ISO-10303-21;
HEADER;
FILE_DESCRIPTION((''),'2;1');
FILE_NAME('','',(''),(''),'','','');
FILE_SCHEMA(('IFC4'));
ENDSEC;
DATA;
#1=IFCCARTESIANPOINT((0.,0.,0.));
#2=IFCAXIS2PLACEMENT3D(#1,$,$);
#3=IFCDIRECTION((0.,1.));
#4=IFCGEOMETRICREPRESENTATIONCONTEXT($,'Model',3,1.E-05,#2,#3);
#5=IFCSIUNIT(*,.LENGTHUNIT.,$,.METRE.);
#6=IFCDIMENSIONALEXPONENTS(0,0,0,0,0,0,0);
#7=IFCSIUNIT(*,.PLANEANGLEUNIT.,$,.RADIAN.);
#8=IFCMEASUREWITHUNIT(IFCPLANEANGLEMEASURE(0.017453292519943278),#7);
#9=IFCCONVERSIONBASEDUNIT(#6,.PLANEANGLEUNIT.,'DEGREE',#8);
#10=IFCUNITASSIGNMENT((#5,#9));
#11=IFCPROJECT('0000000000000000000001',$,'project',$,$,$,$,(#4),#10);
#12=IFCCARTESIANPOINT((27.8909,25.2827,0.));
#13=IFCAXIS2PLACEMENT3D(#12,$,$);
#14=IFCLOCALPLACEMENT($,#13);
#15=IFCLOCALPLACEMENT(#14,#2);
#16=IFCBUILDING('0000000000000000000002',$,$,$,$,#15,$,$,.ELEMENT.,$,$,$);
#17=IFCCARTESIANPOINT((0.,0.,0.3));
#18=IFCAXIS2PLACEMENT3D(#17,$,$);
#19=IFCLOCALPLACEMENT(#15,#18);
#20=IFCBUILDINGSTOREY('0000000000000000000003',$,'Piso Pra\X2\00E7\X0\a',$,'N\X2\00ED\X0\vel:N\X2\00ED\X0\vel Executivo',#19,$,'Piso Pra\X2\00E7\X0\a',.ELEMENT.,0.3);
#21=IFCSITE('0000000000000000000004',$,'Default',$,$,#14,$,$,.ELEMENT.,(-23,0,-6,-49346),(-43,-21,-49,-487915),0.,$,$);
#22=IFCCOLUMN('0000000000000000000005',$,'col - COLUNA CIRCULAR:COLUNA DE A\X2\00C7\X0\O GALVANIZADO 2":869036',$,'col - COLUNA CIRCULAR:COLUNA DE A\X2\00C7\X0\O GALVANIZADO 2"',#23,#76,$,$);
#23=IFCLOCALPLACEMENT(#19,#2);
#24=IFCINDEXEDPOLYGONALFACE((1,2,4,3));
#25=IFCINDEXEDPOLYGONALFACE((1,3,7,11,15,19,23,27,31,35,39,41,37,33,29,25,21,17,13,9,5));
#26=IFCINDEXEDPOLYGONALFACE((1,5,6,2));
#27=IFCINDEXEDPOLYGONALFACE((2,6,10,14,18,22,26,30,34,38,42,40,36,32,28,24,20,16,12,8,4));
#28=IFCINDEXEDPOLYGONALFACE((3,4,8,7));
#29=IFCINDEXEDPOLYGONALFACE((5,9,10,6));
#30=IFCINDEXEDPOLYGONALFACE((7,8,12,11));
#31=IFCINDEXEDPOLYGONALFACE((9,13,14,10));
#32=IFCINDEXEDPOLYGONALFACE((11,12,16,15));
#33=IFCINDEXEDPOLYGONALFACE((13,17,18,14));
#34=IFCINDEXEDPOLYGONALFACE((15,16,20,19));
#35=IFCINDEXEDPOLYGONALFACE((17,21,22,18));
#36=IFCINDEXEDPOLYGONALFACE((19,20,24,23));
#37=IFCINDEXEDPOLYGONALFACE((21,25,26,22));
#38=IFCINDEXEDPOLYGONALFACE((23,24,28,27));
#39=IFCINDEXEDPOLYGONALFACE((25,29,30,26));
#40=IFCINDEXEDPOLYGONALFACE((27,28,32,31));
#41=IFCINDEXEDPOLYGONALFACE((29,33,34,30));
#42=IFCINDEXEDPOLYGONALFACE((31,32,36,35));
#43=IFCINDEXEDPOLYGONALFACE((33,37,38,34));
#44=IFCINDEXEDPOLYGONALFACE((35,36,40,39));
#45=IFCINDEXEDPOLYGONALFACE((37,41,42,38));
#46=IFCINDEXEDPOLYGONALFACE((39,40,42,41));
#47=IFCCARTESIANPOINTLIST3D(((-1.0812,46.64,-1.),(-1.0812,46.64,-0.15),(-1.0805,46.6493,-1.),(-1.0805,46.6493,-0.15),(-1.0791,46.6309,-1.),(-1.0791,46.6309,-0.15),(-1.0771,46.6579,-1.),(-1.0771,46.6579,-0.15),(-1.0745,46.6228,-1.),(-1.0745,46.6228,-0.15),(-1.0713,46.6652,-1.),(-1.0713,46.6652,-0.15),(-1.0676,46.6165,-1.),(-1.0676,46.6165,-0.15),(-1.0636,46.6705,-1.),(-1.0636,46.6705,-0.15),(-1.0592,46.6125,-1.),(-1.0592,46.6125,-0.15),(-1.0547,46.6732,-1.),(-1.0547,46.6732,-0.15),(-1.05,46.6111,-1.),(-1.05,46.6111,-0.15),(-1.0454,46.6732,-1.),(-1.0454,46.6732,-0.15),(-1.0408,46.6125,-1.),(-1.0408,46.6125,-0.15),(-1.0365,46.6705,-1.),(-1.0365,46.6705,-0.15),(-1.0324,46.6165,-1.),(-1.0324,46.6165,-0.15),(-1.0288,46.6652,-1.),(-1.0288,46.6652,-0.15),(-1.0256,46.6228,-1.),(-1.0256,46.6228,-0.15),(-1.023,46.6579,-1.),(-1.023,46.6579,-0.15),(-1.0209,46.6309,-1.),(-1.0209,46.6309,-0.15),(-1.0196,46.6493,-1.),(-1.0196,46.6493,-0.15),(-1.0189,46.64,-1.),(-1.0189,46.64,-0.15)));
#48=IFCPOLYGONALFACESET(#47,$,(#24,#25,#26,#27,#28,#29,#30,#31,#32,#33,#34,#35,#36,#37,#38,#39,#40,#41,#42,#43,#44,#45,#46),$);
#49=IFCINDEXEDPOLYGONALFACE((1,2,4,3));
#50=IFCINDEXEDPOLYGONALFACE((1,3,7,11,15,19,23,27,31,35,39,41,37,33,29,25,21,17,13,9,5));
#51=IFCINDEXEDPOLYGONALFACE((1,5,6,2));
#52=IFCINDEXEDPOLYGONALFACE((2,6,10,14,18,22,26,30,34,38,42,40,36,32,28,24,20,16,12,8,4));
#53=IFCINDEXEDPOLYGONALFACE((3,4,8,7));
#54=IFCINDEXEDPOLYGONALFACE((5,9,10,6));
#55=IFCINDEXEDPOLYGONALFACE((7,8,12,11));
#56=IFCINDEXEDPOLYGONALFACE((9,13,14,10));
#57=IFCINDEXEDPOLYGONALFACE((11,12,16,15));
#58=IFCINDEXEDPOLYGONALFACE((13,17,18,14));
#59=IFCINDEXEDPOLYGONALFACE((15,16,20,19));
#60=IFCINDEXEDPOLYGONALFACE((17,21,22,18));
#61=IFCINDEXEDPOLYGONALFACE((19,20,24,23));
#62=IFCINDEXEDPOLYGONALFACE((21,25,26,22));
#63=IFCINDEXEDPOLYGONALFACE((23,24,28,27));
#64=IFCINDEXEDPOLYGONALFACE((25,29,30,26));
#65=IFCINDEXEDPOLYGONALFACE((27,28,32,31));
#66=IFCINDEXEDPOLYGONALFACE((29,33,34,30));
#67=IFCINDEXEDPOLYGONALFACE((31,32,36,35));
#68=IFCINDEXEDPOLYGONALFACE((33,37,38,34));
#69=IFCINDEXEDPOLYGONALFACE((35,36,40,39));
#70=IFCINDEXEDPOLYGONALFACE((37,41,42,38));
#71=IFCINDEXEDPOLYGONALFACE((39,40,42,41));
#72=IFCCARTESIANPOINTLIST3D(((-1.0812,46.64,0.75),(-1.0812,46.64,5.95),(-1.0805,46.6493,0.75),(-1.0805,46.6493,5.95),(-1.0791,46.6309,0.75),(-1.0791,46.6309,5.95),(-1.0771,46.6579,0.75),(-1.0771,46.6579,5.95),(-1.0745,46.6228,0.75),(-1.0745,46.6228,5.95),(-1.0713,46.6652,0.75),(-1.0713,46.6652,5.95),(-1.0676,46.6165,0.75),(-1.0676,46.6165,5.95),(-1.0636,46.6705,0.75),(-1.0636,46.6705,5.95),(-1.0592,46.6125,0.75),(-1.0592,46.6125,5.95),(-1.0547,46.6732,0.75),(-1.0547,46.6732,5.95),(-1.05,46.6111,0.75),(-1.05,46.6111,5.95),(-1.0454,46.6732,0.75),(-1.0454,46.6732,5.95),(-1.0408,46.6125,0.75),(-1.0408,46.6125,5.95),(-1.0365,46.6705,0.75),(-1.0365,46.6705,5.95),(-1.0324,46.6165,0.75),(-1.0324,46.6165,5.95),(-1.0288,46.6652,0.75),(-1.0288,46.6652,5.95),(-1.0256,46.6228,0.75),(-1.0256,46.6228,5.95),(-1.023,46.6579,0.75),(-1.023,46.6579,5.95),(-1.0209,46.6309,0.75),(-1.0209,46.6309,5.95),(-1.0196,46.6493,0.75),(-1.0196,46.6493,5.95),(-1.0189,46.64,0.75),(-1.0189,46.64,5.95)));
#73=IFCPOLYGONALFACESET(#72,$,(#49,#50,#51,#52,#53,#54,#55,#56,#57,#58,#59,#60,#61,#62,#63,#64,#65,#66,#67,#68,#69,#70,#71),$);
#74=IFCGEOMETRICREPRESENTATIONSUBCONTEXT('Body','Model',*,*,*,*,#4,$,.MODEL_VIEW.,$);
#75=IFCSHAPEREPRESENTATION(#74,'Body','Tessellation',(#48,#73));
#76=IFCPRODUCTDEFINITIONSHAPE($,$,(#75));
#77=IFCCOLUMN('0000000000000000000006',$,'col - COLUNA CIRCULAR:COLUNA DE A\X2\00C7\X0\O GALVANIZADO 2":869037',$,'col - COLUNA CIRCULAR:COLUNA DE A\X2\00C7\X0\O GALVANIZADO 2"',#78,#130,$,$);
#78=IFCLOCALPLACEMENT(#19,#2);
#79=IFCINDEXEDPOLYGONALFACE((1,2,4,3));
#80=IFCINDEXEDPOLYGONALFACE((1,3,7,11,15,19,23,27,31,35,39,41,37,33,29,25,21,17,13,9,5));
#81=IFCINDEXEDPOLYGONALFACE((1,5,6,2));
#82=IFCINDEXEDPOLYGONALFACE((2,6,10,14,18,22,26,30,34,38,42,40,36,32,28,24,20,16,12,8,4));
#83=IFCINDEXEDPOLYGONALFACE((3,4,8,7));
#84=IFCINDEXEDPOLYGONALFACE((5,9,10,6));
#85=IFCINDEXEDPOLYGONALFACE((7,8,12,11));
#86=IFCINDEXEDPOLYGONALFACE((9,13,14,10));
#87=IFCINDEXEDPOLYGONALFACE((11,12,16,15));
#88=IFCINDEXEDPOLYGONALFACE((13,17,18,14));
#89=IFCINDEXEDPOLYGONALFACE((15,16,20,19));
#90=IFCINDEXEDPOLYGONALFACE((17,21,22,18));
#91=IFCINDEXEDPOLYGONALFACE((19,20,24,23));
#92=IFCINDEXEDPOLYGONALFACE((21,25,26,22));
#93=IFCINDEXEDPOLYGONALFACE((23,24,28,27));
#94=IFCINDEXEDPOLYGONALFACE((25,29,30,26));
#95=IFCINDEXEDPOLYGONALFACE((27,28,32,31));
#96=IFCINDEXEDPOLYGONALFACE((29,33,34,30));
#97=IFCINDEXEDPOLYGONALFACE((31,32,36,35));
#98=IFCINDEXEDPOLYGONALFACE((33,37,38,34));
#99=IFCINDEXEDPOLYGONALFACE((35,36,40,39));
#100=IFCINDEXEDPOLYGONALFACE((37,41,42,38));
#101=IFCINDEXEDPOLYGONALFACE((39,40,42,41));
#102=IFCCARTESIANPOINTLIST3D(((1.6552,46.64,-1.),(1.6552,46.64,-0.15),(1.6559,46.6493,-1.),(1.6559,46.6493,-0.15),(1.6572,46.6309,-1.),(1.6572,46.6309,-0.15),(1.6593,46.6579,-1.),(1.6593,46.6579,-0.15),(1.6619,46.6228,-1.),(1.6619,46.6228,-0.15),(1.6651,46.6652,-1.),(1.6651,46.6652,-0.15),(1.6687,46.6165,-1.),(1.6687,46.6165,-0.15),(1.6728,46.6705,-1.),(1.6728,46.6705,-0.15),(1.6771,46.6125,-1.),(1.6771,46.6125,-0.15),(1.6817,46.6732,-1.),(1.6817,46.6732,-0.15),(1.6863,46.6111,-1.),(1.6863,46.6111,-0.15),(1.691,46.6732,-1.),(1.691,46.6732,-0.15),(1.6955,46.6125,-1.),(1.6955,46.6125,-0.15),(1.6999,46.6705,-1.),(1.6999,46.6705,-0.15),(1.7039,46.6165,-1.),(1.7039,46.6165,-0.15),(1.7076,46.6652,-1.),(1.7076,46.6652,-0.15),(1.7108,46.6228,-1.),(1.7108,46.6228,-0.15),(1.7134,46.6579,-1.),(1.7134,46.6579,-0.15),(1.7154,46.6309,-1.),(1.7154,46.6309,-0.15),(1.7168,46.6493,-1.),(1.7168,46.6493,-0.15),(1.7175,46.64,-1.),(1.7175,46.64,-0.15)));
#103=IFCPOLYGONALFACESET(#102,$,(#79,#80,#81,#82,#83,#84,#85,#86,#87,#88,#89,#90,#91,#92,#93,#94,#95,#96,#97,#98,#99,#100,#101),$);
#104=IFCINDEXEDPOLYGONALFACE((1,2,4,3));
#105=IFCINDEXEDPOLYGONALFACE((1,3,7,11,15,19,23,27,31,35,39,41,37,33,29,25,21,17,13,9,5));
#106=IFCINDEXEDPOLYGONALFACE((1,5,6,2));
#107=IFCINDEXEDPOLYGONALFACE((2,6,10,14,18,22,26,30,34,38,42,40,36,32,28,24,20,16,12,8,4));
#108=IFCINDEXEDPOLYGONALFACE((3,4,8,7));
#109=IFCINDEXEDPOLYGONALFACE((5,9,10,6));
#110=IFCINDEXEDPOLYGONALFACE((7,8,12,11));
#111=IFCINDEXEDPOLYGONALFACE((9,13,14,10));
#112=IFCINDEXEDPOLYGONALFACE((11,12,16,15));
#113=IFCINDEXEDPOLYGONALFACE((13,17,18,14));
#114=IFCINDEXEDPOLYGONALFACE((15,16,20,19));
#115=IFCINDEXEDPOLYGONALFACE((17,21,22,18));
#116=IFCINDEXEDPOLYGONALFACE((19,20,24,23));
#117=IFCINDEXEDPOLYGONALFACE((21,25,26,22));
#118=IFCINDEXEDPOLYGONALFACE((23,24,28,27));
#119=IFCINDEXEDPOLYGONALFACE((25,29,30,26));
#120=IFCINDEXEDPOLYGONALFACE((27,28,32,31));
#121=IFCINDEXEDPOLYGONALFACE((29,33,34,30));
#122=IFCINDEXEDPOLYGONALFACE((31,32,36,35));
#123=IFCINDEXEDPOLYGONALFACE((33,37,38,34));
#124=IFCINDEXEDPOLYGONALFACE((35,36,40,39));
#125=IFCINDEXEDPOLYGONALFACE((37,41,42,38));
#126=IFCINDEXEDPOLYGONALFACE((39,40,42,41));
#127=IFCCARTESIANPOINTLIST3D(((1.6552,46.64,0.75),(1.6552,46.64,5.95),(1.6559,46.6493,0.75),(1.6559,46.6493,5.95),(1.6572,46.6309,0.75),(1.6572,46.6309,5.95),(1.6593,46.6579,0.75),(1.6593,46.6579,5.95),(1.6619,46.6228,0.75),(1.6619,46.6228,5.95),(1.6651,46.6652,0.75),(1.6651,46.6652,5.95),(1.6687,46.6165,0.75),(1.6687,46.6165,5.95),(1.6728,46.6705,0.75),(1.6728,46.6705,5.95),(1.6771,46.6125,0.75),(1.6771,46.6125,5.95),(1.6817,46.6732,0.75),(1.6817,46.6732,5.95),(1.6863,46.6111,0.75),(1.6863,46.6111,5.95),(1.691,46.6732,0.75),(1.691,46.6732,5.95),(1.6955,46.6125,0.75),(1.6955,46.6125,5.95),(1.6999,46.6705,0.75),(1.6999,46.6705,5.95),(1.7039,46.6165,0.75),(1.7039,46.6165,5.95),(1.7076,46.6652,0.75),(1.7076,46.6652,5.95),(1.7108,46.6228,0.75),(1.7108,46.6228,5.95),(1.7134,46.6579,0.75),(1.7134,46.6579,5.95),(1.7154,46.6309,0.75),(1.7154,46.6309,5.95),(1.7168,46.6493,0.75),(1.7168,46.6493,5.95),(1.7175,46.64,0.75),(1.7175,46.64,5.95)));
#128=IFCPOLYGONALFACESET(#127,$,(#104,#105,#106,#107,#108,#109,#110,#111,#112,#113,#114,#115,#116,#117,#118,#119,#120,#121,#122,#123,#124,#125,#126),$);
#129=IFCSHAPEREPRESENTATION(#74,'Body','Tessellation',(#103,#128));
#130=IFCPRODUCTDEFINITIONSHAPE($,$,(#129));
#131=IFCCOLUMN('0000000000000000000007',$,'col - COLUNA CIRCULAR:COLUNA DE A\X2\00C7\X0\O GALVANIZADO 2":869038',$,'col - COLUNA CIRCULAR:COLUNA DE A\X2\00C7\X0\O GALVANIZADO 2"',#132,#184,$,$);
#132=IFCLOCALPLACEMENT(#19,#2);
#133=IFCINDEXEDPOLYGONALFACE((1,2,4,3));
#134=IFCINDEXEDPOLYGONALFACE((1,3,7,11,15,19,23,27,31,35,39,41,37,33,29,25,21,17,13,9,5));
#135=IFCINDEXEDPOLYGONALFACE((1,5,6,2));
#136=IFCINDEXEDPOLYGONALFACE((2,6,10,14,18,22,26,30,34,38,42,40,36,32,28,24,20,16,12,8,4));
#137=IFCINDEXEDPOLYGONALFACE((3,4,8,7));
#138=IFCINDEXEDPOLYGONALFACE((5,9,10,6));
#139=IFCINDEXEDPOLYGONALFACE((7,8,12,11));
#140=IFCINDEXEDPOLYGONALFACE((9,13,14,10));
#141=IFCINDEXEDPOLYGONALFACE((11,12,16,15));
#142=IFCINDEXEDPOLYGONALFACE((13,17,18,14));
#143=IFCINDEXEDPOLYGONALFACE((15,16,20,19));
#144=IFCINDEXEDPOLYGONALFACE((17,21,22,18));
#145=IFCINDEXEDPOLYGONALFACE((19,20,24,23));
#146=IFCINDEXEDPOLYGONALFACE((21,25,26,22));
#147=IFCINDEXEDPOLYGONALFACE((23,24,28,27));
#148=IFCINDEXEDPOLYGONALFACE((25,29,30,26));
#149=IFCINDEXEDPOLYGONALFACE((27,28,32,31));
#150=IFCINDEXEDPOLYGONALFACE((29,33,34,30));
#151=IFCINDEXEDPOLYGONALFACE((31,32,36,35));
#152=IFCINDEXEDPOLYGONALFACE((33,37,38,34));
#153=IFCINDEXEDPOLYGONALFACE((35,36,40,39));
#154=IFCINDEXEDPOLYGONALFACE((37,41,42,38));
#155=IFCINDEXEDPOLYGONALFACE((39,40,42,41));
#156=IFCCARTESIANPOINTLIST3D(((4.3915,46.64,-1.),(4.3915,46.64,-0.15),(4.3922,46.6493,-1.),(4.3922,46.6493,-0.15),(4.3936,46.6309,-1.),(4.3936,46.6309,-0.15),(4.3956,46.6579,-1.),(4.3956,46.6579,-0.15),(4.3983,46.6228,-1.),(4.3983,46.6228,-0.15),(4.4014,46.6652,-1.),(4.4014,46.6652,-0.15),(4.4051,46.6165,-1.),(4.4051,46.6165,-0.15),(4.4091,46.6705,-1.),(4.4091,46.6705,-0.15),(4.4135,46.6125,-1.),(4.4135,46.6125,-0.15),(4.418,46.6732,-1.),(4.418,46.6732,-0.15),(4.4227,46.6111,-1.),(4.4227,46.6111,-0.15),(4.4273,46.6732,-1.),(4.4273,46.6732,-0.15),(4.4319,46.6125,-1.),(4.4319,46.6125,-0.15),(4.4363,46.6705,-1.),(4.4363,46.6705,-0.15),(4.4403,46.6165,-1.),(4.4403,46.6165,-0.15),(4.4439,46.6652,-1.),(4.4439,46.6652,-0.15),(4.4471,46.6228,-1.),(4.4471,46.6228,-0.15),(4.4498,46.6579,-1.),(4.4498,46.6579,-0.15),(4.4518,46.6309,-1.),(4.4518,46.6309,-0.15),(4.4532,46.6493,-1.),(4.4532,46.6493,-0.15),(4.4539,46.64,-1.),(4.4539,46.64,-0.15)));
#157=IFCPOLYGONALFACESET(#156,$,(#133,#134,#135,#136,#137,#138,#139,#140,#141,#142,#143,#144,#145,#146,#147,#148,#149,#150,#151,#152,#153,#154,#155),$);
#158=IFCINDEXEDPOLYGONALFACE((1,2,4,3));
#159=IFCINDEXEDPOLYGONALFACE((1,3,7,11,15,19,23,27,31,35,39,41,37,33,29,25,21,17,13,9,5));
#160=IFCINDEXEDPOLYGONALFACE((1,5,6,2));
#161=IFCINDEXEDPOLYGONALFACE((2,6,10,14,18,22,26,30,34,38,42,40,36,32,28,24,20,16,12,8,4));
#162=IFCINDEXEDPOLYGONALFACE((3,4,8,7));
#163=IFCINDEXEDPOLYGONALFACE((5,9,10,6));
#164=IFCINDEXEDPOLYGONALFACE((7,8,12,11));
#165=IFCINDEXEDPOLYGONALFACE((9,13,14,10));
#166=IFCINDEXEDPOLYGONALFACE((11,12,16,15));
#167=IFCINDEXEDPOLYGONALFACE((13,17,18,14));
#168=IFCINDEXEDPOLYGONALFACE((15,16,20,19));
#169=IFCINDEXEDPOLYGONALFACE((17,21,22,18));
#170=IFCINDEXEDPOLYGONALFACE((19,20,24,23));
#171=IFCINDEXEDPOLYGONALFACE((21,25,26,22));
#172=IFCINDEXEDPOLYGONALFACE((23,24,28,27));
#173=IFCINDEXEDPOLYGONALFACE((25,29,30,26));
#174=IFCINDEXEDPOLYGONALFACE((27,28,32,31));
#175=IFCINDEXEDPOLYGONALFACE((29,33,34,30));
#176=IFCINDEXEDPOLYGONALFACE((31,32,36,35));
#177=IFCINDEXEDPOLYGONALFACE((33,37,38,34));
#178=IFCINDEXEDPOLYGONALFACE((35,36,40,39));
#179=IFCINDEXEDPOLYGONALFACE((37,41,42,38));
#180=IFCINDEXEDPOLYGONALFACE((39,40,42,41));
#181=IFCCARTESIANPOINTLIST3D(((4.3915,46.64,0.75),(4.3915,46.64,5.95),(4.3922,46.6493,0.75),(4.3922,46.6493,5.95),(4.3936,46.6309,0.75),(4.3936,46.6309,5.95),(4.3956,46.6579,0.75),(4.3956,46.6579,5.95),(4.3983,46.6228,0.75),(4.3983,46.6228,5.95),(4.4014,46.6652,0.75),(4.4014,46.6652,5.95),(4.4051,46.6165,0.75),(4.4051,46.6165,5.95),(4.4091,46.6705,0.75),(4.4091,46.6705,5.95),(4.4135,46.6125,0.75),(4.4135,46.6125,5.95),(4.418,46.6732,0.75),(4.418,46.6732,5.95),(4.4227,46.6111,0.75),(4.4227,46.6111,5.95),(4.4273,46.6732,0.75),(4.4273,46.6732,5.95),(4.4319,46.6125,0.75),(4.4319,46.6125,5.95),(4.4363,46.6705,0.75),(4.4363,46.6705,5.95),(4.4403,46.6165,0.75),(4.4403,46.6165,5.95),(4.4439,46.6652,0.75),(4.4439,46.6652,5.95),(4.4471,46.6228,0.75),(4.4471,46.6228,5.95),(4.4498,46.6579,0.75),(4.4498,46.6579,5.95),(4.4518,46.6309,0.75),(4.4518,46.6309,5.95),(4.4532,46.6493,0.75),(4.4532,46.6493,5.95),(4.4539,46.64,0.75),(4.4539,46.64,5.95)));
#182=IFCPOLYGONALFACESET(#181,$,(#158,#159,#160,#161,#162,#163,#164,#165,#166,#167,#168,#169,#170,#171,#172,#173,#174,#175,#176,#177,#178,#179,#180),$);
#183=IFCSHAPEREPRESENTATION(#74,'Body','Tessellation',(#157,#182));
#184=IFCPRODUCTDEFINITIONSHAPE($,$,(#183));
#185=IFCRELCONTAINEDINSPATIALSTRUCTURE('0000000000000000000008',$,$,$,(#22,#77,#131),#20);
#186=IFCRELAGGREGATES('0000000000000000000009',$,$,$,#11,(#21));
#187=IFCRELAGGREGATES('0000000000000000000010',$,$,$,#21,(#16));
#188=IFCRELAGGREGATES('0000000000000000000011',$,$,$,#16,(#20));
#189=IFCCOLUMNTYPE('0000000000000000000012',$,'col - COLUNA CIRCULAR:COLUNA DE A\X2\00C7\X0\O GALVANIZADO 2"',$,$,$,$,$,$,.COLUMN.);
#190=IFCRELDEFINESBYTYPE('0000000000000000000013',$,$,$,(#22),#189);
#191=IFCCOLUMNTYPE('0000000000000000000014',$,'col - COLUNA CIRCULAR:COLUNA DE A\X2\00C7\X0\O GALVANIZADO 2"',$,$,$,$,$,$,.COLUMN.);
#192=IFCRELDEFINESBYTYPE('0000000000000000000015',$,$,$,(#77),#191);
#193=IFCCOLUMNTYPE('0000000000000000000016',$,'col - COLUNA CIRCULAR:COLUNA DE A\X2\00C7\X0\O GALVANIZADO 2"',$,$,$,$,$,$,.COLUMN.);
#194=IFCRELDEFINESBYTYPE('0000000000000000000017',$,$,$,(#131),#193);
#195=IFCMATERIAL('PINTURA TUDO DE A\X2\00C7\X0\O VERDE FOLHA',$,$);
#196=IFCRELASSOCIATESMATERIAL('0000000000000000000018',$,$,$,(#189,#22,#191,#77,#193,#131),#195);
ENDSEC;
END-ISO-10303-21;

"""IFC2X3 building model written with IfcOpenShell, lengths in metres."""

from ifc_helpers import new_model, entity, si_unit, converted_unit, direction, frame, origin, origin_2d_with_axis, place, context, subcontext, project, spatial, circle, extrude, source, transform, mapped, material, type_object, type_shapes, element, save


model = new_model("IFC2X3")

# Units and contexts
model_context = context("Model", 3, precision=1e-05, world=origin(), true_north=direction((0.0, 1.0)))
body_context = subcontext(model_context, "Body", "Model", "MODEL_VIEW")
ifc_project = project(units=[si_unit("LENGTHUNIT", "METRE"), converted_unit("PLANEANGLEUNIT", "DEGREE", entity("IfcPlaneAngleMeasure", 0.017453292519943278), si_unit("PLANEANGLEUNIT", "RADIAN"), dimensions=[0, 0, 0, 0, 0, 0, 0])], contexts=[model_context])

# Site, building, storey
site_placement = place(None, frame((27.8909, 25.2827, 0.0)))
site = spatial("IfcSite", under=ifc_project, at=site_placement, Name="Default", CompositionType="ELEMENT", RefLatitude=(-23, 0, -6, -49346), RefLongitude=(-43, -21, -49, -487915), RefElevation=0.0)
building_placement = place(site_placement, origin())
building = spatial("IfcBuilding", under=site, at=building_placement, CompositionType="ELEMENT")
storey_placement = place(building_placement, frame((0.0, 0.0, 0.3)))
storey = spatial("IfcBuildingStorey", under=building, at=storey_placement, Name="Piso Praça", ObjectType="Nível:Nível Executivo", LongName="Piso Praça", CompositionType="ELEMENT", Elevation=0.3)

# Columns
ifc_material = material(Name="PINTURA TUDO DE AÇO VERDE FOLHA")
column_type_1 = type_object("IfcColumnType", Name="col - COLUNA CIRCULAR:COLUNA DE AÇO GALVANIZADO 2\"", PredefinedType="COLUMN", material=ifc_material)
shared_shape_1 = source(origin(), body_context, "Body", "SweptSolid", [
    extrude(circle(Radius=0.0312, at=origin_2d_with_axis()), frame((-1.05, 46.6423, -0.7), z_axis=(0.0, 0.0, 1.0), x_axis=(0.0, -1.0, 0.0)), (0.0, 0.0, 1.0), 0.85),
    extrude(circle(Radius=0.0312, at=origin_2d_with_axis()), frame((-1.05, 46.6423, 1.05), z_axis=(0.0, 0.0, 1.0), x_axis=(0.0, -1.0, 0.0)), (0.0, 0.0, 1.0), 5.2),
])
type_shapes(column_type_1, [shared_shape_1])
column_1_placement = place(storey_placement, frame((0.0, 0.0, -0.3)))
element("IfcColumn", 1, at=column_1_placement, inside=storey, type_object=column_type_1, material=ifc_material, Name="col - COLUNA CIRCULAR:COLUNA DE AÇO GALVANIZADO 2\":869036", ObjectType="col - COLUNA CIRCULAR:COLUNA DE AÇO GALVANIZADO 2\"", context=body_context, shape_type="MappedRepresentation", body=[
    mapped(shared_shape_1, transform((0.0, 0.0, 0.0), scale=1.0)),
])
column_type_2 = type_object("IfcColumnType", Name="col - COLUNA CIRCULAR:COLUNA DE AÇO GALVANIZADO 2\"", PredefinedType="COLUMN", material=ifc_material)
shared_shape_2 = source(origin(), body_context, "Body", "SweptSolid", [
    extrude(circle(Radius=0.0312, at=origin_2d_with_axis()), frame((1.6863, 46.6423, -0.7), z_axis=(0.0, 0.0, 1.0), x_axis=(0.0, -1.0, 0.0)), (0.0, 0.0, 1.0), 0.85),
    extrude(circle(Radius=0.0312, at=origin_2d_with_axis()), frame((1.6863, 46.6423, 1.05), z_axis=(0.0, 0.0, 1.0), x_axis=(0.0, -1.0, 0.0)), (0.0, 0.0, 1.0), 5.2),
])
type_shapes(column_type_2, [shared_shape_2])
column_2_placement = place(storey_placement, frame((0.0, 0.0, -0.3)))
element("IfcColumn", 2, at=column_2_placement, inside=storey, type_object=column_type_2, material=ifc_material, Name="col - COLUNA CIRCULAR:COLUNA DE AÇO GALVANIZADO 2\":869037", ObjectType="col - COLUNA CIRCULAR:COLUNA DE AÇO GALVANIZADO 2\"", context=body_context, shape_type="MappedRepresentation", body=[
    mapped(shared_shape_2, transform((0.0, 0.0, 0.0), scale=1.0)),
])
column_type_3 = type_object("IfcColumnType", Name="col - COLUNA CIRCULAR:COLUNA DE AÇO GALVANIZADO 2\"", PredefinedType="COLUMN", material=ifc_material)
shared_shape_3 = source(origin(), body_context, "Body", "SweptSolid", [
    extrude(circle(Radius=0.0312, at=origin_2d_with_axis()), frame((4.4227, 46.6423, -0.7), z_axis=(0.0, 0.0, 1.0), x_axis=(0.0, -1.0, 0.0)), (0.0, 0.0, 1.0), 0.85),
    extrude(circle(Radius=0.0312, at=origin_2d_with_axis()), frame((4.4227, 46.6423, 1.05), z_axis=(0.0, 0.0, 1.0), x_axis=(0.0, -1.0, 0.0)), (0.0, 0.0, 1.0), 5.2),
])
type_shapes(column_type_3, [shared_shape_3])
column_3_placement = place(storey_placement, frame((0.0, 0.0, -0.3)))
element("IfcColumn", 3, at=column_3_placement, inside=storey, type_object=column_type_3, material=ifc_material, Name="col - COLUNA CIRCULAR:COLUNA DE AÇO GALVANIZADO 2\":869038", ObjectType="col - COLUNA CIRCULAR:COLUNA DE AÇO GALVANIZADO 2\"", context=body_context, shape_type="MappedRepresentation", body=[
    mapped(shared_shape_3, transform((0.0, 0.0, 0.0), scale=1.0)),
])

save(model, "model.ifc")
